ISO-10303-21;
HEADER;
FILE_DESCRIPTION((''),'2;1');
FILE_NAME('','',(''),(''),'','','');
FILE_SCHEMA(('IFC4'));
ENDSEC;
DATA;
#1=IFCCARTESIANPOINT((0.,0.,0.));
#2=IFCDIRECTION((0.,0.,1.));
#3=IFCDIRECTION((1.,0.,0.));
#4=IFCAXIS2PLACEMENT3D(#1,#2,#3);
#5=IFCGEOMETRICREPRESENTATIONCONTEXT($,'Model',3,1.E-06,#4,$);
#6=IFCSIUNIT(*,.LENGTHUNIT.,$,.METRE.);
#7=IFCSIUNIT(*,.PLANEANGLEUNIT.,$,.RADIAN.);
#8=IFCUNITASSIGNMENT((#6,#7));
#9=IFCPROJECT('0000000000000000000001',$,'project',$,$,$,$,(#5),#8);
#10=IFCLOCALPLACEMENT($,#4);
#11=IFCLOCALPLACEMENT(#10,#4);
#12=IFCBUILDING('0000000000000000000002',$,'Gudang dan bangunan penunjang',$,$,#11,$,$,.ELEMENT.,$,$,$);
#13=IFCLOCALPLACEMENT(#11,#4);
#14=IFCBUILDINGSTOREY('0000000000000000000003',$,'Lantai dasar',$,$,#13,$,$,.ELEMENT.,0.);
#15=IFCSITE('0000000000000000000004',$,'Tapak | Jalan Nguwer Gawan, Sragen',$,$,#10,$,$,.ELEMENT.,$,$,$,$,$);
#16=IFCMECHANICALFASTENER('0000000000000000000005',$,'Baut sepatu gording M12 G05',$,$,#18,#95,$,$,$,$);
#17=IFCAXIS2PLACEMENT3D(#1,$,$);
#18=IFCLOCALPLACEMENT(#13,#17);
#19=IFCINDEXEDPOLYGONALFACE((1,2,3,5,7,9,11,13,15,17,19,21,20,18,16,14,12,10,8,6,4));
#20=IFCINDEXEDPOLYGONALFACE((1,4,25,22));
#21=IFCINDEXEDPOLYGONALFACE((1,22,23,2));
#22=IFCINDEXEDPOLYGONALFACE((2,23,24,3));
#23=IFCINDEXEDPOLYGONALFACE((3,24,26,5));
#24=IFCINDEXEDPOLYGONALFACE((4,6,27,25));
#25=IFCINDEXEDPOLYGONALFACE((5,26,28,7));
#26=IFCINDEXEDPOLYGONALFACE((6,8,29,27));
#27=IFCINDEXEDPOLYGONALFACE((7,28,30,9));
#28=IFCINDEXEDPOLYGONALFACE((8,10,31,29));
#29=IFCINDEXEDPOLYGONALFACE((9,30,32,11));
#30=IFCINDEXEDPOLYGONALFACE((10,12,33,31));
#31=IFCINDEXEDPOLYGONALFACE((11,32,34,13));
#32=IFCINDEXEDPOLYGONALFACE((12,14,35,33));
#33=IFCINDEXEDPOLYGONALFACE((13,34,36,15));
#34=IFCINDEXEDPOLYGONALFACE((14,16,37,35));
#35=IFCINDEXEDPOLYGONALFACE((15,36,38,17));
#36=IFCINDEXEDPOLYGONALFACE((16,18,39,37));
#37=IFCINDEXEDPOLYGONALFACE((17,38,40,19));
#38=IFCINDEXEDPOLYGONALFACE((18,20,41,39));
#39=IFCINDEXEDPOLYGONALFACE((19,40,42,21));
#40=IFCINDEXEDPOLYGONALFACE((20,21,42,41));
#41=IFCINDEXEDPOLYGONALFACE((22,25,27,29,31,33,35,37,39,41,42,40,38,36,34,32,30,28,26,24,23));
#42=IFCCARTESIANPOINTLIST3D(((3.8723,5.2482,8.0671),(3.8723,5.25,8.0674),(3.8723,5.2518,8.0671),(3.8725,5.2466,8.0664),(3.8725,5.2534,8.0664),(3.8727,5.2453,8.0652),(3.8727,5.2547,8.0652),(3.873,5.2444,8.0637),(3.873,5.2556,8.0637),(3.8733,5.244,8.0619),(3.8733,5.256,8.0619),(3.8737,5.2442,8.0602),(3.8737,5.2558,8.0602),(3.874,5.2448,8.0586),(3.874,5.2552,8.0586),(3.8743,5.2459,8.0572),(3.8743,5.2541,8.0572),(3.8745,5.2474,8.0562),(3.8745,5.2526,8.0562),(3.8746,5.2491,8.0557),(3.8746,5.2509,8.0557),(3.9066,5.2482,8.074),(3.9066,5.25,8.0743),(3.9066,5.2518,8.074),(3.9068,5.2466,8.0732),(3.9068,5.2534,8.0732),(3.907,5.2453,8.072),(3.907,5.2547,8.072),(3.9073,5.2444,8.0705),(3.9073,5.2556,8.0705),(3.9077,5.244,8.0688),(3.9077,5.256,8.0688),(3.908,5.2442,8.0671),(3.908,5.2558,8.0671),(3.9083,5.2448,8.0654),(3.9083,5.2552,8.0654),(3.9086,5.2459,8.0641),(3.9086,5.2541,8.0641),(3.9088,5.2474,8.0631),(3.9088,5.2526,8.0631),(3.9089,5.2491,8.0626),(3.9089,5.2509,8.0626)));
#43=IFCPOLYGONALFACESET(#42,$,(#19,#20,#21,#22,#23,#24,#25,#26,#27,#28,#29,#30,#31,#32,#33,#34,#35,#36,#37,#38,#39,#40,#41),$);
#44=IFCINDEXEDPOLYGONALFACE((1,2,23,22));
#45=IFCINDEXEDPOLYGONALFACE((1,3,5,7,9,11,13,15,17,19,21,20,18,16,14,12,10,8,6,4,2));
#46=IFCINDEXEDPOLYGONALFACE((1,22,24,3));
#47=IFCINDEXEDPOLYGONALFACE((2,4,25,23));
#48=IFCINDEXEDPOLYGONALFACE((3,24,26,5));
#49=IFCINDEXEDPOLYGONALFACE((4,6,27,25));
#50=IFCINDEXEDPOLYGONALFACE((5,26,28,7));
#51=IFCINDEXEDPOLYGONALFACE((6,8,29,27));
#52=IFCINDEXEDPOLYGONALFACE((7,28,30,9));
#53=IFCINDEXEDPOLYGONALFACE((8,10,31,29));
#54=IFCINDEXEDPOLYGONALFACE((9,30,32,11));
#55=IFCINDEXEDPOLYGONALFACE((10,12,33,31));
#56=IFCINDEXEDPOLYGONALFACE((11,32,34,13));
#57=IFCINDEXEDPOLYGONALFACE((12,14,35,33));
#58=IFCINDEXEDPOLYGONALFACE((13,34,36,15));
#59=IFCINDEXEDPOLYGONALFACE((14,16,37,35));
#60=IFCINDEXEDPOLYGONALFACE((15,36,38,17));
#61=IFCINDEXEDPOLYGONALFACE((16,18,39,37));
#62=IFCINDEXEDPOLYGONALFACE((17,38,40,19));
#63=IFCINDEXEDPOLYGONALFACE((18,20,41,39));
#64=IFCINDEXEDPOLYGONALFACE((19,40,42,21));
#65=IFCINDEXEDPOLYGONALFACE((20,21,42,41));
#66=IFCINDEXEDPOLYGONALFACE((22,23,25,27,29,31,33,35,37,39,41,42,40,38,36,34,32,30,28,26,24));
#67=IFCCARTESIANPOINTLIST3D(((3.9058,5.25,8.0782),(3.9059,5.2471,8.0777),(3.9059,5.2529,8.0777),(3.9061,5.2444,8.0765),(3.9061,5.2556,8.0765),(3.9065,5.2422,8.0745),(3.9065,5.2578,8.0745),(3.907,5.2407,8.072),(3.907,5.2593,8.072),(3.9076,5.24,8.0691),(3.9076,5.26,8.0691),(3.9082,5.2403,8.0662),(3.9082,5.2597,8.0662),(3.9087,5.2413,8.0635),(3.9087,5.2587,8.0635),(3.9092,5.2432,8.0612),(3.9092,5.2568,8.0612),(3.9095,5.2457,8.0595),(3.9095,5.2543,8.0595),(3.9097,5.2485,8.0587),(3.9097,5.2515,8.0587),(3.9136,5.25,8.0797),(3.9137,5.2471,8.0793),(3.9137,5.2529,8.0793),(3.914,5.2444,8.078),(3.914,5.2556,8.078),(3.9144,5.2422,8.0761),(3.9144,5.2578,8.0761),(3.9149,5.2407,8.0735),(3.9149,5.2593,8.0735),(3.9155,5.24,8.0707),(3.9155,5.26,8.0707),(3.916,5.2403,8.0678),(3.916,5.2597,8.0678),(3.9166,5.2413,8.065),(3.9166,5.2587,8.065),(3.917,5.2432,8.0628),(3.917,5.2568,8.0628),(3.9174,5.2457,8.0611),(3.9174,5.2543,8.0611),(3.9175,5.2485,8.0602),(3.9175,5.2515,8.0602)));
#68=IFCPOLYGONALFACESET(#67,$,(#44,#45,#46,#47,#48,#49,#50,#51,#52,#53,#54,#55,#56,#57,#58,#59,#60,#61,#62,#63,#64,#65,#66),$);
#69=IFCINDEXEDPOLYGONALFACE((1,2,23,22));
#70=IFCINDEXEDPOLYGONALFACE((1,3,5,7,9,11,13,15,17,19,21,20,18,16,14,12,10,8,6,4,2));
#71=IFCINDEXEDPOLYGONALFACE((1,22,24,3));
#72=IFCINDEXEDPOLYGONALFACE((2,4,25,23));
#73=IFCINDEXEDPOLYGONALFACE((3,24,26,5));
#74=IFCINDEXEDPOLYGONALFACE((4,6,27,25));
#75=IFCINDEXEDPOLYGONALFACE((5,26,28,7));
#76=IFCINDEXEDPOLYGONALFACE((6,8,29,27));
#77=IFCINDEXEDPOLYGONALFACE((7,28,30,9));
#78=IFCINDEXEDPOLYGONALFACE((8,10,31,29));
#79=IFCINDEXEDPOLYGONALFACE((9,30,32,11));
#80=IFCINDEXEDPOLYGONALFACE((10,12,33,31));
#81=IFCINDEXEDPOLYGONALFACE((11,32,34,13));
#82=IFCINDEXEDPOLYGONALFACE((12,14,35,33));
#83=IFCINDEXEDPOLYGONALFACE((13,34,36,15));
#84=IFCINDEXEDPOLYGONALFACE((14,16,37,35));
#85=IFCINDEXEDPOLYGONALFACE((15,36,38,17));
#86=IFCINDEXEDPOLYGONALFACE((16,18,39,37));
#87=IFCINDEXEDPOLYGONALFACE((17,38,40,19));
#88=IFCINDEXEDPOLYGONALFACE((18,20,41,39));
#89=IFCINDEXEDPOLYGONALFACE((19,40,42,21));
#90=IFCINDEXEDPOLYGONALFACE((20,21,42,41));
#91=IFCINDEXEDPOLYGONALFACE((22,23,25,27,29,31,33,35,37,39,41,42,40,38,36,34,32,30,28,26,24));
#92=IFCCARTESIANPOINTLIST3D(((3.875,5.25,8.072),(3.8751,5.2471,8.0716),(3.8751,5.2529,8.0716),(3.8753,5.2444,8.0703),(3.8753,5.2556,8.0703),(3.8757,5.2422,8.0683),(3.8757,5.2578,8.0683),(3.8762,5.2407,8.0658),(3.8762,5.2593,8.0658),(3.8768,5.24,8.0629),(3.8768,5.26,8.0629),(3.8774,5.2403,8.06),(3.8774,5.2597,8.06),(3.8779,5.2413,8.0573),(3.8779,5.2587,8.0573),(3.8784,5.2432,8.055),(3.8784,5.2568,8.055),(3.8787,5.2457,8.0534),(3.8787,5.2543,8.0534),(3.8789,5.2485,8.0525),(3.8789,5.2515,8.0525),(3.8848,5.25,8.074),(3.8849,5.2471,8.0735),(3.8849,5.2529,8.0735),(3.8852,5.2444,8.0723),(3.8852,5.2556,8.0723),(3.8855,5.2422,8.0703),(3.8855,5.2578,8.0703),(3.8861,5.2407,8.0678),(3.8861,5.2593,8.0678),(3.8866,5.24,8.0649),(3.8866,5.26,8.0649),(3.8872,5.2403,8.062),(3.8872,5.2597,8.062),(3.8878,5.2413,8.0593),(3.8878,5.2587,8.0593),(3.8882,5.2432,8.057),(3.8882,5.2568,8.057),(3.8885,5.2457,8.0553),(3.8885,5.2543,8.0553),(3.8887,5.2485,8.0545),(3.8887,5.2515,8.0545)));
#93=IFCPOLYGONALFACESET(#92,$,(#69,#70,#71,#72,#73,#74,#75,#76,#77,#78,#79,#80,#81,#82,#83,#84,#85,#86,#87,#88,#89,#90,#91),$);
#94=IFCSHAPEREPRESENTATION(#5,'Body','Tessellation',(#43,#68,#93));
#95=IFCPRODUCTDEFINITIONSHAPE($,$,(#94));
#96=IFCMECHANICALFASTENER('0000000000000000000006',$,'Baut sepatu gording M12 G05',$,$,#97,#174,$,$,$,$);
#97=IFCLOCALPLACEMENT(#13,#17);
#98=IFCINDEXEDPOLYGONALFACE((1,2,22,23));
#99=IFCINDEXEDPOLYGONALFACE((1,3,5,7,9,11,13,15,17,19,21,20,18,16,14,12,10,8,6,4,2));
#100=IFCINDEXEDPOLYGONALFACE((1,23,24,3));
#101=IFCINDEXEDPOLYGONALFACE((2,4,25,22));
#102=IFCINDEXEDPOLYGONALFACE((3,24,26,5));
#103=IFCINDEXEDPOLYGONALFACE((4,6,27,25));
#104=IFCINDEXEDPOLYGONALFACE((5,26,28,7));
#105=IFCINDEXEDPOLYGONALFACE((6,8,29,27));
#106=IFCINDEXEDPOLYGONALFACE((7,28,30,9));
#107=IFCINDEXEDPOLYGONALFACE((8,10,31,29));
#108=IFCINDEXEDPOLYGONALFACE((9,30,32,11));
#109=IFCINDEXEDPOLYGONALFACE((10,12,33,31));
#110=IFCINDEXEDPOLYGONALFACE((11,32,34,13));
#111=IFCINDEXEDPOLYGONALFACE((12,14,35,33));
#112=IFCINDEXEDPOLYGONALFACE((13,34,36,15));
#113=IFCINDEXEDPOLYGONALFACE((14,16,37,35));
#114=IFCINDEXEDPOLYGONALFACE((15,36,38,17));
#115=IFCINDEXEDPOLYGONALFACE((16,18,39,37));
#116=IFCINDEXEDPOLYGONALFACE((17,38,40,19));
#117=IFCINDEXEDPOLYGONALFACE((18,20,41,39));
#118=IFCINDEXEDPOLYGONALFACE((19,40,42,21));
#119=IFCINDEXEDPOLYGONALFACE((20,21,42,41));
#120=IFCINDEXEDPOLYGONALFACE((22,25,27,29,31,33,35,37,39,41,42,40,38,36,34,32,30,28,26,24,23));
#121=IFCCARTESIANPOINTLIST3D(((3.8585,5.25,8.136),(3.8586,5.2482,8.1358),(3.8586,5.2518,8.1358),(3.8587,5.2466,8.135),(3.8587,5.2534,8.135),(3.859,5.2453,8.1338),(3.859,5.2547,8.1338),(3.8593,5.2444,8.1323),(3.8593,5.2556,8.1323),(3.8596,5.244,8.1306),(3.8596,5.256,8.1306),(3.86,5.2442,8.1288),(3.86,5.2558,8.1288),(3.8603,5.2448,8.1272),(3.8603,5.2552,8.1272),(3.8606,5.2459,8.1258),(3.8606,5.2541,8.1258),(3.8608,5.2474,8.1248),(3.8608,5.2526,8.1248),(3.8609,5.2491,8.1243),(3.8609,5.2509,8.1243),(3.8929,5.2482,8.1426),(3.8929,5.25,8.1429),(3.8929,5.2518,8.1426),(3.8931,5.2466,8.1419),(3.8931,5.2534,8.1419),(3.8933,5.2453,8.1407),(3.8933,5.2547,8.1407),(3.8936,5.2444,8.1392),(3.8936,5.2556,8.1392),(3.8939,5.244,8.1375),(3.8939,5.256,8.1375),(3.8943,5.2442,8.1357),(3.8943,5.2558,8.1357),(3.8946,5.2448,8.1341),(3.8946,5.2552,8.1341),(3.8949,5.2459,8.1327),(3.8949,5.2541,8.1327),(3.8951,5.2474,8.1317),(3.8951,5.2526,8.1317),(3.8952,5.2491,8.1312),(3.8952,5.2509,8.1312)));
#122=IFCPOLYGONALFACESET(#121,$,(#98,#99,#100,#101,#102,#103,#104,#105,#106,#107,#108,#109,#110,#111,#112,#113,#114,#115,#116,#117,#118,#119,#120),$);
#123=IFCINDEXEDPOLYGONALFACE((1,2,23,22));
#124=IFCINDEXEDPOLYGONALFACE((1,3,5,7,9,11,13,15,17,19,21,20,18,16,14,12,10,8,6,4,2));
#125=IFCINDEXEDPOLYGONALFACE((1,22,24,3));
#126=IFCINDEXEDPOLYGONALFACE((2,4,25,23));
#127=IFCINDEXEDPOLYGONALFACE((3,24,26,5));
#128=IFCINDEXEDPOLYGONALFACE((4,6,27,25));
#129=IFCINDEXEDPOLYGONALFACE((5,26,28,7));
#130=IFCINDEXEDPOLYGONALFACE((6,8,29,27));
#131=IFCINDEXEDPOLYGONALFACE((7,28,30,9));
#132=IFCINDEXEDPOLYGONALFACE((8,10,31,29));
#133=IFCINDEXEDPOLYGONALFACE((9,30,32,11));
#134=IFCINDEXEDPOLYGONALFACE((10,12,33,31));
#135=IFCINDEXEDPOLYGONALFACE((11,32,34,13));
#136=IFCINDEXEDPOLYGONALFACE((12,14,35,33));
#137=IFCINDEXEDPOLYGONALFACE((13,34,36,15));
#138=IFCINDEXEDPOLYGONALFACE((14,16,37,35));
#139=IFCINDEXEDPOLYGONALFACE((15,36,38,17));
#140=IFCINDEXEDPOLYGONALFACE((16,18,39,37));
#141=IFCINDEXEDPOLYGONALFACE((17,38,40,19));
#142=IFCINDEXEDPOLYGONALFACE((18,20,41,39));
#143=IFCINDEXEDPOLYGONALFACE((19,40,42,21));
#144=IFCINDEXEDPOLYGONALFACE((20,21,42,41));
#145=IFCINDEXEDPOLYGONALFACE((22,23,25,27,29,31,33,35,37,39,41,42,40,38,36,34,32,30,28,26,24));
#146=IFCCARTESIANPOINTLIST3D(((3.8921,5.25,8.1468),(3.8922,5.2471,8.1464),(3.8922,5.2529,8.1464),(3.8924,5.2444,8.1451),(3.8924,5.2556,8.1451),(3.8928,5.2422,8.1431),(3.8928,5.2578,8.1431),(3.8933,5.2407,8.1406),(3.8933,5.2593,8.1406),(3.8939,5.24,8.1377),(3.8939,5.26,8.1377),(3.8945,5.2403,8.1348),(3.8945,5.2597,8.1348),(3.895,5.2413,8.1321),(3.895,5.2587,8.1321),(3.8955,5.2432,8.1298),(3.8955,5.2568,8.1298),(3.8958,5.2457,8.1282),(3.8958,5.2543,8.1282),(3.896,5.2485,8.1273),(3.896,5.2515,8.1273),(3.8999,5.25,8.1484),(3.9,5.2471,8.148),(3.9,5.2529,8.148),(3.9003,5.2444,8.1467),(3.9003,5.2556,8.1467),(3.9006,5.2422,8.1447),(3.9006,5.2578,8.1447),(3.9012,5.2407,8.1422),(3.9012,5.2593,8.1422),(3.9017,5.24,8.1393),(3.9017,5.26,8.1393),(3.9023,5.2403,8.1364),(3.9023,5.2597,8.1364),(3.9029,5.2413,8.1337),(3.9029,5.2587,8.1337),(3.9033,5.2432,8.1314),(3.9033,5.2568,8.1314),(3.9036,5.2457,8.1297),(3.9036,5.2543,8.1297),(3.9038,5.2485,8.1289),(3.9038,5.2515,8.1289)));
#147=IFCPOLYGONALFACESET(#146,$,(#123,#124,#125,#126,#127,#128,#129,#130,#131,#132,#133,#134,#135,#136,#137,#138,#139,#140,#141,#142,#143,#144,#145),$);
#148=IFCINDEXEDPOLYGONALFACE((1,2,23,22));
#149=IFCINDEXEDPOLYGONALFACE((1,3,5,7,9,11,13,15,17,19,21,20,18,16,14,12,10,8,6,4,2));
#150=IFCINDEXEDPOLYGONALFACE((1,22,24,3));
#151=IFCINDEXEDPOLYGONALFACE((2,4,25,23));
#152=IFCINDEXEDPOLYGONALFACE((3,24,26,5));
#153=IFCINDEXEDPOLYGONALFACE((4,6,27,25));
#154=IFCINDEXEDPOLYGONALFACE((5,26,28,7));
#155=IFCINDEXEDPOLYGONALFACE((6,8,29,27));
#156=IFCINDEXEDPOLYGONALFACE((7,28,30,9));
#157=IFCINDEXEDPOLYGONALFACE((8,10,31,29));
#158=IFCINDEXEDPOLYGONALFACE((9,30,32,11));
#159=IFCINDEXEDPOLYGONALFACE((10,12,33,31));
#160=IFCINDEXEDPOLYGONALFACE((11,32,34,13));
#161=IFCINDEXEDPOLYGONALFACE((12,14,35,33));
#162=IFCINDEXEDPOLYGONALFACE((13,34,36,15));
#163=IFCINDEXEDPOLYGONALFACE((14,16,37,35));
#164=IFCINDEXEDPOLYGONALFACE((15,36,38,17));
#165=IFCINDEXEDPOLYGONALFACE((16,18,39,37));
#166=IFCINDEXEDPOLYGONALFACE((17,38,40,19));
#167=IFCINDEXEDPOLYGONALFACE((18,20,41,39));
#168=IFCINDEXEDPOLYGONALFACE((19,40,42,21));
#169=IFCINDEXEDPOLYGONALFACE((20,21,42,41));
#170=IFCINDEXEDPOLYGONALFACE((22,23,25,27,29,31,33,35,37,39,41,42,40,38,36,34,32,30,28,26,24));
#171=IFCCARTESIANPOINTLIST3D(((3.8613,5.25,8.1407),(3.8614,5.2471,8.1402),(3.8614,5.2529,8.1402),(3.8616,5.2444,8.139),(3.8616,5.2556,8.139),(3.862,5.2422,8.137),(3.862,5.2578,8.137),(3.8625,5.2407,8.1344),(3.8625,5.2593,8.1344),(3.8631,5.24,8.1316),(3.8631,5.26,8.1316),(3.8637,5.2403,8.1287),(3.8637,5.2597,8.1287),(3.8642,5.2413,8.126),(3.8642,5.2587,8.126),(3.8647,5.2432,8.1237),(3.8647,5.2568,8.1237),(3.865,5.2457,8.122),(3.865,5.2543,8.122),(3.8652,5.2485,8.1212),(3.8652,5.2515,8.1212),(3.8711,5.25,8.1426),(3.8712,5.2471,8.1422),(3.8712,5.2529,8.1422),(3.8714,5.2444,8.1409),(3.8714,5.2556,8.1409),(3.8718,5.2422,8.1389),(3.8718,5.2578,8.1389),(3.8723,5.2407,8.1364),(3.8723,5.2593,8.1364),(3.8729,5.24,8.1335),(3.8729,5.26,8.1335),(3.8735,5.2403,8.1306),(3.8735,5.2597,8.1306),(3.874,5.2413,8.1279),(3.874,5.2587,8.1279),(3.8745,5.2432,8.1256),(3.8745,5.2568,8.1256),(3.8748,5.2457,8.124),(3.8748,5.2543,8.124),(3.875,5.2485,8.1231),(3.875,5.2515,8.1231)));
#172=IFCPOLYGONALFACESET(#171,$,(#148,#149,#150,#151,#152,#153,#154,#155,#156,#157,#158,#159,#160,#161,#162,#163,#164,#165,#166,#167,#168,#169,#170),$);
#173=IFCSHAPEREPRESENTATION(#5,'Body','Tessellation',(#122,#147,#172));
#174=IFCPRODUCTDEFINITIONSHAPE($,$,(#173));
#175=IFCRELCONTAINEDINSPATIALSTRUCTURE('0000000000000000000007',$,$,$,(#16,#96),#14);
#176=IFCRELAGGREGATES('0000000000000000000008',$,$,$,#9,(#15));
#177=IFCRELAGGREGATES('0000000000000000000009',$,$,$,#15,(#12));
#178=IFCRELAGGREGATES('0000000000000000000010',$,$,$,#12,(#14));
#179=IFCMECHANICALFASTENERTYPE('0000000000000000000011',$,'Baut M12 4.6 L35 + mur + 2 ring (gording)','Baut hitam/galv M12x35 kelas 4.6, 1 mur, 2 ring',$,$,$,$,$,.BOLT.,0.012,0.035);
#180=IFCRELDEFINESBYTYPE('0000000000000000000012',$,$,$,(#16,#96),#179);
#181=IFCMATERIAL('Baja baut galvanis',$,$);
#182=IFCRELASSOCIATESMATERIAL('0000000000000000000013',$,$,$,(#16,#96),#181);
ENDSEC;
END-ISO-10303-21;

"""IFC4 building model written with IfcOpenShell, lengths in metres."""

from ifc_helpers import new_model, si_unit, frame, origin_with_axes, place, context, project, spatial, circle, extrude, source, transform, mapped, material, type_object, type_shapes, element, save


model = new_model("IFC4")

# Units and contexts
model_context = context("Model", 3, precision=1e-06, world=origin_with_axes())
ifc_project = project(units=[si_unit("LENGTHUNIT", "METRE"), si_unit("PLANEANGLEUNIT", "RADIAN")], contexts=[model_context])

# Site, building, storey
site_placement = place(None, origin_with_axes())
site = spatial("IfcSite", under=ifc_project, at=site_placement, Name="Tapak | Jalan Nguwer Gawan, Sragen", CompositionType="ELEMENT")
building_placement = place(site_placement, origin_with_axes())
building = spatial("IfcBuilding", under=site, at=building_placement, Name="Gudang dan bangunan penunjang", CompositionType="ELEMENT")
storey_placement = place(building_placement, origin_with_axes())
storey = spatial("IfcBuildingStorey", under=building, at=storey_placement, Name="Lantai dasar", CompositionType="ELEMENT", Elevation=0.0)

# Shared definitions
placement = place(None, origin_with_axes())

# Mechanical fasteners
ifc_material_1 = material(Name="Baja baut galvanis")
mechanical_fastener_type = type_object("IfcMechanicalFastenerType", Name="Baut M12 4.6 L35 + mur + 2 ring (gording)", Description="Baut hitam/galv M12x35 kelas 4.6, 1 mur, 2 ring", NominalDiameter=0.012, NominalLength=0.035, PredefinedType="BOLT")
shared_shape = source(origin_with_axes(), model_context, "Body", "SweptSolid", [
    extrude(circle(Radius=0.006), origin_with_axes(), (0.0, 0.0, 1.0), 0.035),
    extrude(circle(Radius=0.01), frame((0.0, 0.0, -0.008), z_axis=(0.0, 0.0, 1.0), x_axis=(1.0, 0.0, 0.0)), (0.0, 0.0, 1.0), 0.008),
    extrude(circle(Radius=0.01), frame((0.0, 0.0, 0.0214), z_axis=(0.0, 0.0, 1.0), x_axis=(1.0, 0.0, 0.0)), (0.0, 0.0, 1.0), 0.01),
])
type_shapes(mechanical_fastener_type, [shared_shape])
element("IfcMechanicalFastener", 1, at=placement, inside=storey, type_object=mechanical_fastener_type, material=ifc_material_1, Name="Baut sepatu gording M12 G05", context=model_context, shape_type="MappedRepresentation", body=[
    mapped(shared_shape, transform((3.9078, 5.25, 8.0684), x_axis=(-0.196116, 0.0, 0.980581), y_axis=(0.0, 1.0, 0.0), z_axis=(-0.980581, 0.0, -0.196116), scale=1.0)),
])
element("IfcMechanicalFastener", 2, at=placement, inside=storey, type_object=mechanical_fastener_type, material=ifc_material_1, Name="Baut sepatu gording M12 G05", context=model_context, shape_type="MappedRepresentation", body=[
    mapped(shared_shape, transform((3.894, 5.25, 8.137), x_axis=(-0.196116, 0.0, 0.980581), y_axis=(0.0, 1.0, 0.0), z_axis=(-0.980581, 0.0, -0.196116), scale=1.0)),
])

save(model, "model.ifc")
